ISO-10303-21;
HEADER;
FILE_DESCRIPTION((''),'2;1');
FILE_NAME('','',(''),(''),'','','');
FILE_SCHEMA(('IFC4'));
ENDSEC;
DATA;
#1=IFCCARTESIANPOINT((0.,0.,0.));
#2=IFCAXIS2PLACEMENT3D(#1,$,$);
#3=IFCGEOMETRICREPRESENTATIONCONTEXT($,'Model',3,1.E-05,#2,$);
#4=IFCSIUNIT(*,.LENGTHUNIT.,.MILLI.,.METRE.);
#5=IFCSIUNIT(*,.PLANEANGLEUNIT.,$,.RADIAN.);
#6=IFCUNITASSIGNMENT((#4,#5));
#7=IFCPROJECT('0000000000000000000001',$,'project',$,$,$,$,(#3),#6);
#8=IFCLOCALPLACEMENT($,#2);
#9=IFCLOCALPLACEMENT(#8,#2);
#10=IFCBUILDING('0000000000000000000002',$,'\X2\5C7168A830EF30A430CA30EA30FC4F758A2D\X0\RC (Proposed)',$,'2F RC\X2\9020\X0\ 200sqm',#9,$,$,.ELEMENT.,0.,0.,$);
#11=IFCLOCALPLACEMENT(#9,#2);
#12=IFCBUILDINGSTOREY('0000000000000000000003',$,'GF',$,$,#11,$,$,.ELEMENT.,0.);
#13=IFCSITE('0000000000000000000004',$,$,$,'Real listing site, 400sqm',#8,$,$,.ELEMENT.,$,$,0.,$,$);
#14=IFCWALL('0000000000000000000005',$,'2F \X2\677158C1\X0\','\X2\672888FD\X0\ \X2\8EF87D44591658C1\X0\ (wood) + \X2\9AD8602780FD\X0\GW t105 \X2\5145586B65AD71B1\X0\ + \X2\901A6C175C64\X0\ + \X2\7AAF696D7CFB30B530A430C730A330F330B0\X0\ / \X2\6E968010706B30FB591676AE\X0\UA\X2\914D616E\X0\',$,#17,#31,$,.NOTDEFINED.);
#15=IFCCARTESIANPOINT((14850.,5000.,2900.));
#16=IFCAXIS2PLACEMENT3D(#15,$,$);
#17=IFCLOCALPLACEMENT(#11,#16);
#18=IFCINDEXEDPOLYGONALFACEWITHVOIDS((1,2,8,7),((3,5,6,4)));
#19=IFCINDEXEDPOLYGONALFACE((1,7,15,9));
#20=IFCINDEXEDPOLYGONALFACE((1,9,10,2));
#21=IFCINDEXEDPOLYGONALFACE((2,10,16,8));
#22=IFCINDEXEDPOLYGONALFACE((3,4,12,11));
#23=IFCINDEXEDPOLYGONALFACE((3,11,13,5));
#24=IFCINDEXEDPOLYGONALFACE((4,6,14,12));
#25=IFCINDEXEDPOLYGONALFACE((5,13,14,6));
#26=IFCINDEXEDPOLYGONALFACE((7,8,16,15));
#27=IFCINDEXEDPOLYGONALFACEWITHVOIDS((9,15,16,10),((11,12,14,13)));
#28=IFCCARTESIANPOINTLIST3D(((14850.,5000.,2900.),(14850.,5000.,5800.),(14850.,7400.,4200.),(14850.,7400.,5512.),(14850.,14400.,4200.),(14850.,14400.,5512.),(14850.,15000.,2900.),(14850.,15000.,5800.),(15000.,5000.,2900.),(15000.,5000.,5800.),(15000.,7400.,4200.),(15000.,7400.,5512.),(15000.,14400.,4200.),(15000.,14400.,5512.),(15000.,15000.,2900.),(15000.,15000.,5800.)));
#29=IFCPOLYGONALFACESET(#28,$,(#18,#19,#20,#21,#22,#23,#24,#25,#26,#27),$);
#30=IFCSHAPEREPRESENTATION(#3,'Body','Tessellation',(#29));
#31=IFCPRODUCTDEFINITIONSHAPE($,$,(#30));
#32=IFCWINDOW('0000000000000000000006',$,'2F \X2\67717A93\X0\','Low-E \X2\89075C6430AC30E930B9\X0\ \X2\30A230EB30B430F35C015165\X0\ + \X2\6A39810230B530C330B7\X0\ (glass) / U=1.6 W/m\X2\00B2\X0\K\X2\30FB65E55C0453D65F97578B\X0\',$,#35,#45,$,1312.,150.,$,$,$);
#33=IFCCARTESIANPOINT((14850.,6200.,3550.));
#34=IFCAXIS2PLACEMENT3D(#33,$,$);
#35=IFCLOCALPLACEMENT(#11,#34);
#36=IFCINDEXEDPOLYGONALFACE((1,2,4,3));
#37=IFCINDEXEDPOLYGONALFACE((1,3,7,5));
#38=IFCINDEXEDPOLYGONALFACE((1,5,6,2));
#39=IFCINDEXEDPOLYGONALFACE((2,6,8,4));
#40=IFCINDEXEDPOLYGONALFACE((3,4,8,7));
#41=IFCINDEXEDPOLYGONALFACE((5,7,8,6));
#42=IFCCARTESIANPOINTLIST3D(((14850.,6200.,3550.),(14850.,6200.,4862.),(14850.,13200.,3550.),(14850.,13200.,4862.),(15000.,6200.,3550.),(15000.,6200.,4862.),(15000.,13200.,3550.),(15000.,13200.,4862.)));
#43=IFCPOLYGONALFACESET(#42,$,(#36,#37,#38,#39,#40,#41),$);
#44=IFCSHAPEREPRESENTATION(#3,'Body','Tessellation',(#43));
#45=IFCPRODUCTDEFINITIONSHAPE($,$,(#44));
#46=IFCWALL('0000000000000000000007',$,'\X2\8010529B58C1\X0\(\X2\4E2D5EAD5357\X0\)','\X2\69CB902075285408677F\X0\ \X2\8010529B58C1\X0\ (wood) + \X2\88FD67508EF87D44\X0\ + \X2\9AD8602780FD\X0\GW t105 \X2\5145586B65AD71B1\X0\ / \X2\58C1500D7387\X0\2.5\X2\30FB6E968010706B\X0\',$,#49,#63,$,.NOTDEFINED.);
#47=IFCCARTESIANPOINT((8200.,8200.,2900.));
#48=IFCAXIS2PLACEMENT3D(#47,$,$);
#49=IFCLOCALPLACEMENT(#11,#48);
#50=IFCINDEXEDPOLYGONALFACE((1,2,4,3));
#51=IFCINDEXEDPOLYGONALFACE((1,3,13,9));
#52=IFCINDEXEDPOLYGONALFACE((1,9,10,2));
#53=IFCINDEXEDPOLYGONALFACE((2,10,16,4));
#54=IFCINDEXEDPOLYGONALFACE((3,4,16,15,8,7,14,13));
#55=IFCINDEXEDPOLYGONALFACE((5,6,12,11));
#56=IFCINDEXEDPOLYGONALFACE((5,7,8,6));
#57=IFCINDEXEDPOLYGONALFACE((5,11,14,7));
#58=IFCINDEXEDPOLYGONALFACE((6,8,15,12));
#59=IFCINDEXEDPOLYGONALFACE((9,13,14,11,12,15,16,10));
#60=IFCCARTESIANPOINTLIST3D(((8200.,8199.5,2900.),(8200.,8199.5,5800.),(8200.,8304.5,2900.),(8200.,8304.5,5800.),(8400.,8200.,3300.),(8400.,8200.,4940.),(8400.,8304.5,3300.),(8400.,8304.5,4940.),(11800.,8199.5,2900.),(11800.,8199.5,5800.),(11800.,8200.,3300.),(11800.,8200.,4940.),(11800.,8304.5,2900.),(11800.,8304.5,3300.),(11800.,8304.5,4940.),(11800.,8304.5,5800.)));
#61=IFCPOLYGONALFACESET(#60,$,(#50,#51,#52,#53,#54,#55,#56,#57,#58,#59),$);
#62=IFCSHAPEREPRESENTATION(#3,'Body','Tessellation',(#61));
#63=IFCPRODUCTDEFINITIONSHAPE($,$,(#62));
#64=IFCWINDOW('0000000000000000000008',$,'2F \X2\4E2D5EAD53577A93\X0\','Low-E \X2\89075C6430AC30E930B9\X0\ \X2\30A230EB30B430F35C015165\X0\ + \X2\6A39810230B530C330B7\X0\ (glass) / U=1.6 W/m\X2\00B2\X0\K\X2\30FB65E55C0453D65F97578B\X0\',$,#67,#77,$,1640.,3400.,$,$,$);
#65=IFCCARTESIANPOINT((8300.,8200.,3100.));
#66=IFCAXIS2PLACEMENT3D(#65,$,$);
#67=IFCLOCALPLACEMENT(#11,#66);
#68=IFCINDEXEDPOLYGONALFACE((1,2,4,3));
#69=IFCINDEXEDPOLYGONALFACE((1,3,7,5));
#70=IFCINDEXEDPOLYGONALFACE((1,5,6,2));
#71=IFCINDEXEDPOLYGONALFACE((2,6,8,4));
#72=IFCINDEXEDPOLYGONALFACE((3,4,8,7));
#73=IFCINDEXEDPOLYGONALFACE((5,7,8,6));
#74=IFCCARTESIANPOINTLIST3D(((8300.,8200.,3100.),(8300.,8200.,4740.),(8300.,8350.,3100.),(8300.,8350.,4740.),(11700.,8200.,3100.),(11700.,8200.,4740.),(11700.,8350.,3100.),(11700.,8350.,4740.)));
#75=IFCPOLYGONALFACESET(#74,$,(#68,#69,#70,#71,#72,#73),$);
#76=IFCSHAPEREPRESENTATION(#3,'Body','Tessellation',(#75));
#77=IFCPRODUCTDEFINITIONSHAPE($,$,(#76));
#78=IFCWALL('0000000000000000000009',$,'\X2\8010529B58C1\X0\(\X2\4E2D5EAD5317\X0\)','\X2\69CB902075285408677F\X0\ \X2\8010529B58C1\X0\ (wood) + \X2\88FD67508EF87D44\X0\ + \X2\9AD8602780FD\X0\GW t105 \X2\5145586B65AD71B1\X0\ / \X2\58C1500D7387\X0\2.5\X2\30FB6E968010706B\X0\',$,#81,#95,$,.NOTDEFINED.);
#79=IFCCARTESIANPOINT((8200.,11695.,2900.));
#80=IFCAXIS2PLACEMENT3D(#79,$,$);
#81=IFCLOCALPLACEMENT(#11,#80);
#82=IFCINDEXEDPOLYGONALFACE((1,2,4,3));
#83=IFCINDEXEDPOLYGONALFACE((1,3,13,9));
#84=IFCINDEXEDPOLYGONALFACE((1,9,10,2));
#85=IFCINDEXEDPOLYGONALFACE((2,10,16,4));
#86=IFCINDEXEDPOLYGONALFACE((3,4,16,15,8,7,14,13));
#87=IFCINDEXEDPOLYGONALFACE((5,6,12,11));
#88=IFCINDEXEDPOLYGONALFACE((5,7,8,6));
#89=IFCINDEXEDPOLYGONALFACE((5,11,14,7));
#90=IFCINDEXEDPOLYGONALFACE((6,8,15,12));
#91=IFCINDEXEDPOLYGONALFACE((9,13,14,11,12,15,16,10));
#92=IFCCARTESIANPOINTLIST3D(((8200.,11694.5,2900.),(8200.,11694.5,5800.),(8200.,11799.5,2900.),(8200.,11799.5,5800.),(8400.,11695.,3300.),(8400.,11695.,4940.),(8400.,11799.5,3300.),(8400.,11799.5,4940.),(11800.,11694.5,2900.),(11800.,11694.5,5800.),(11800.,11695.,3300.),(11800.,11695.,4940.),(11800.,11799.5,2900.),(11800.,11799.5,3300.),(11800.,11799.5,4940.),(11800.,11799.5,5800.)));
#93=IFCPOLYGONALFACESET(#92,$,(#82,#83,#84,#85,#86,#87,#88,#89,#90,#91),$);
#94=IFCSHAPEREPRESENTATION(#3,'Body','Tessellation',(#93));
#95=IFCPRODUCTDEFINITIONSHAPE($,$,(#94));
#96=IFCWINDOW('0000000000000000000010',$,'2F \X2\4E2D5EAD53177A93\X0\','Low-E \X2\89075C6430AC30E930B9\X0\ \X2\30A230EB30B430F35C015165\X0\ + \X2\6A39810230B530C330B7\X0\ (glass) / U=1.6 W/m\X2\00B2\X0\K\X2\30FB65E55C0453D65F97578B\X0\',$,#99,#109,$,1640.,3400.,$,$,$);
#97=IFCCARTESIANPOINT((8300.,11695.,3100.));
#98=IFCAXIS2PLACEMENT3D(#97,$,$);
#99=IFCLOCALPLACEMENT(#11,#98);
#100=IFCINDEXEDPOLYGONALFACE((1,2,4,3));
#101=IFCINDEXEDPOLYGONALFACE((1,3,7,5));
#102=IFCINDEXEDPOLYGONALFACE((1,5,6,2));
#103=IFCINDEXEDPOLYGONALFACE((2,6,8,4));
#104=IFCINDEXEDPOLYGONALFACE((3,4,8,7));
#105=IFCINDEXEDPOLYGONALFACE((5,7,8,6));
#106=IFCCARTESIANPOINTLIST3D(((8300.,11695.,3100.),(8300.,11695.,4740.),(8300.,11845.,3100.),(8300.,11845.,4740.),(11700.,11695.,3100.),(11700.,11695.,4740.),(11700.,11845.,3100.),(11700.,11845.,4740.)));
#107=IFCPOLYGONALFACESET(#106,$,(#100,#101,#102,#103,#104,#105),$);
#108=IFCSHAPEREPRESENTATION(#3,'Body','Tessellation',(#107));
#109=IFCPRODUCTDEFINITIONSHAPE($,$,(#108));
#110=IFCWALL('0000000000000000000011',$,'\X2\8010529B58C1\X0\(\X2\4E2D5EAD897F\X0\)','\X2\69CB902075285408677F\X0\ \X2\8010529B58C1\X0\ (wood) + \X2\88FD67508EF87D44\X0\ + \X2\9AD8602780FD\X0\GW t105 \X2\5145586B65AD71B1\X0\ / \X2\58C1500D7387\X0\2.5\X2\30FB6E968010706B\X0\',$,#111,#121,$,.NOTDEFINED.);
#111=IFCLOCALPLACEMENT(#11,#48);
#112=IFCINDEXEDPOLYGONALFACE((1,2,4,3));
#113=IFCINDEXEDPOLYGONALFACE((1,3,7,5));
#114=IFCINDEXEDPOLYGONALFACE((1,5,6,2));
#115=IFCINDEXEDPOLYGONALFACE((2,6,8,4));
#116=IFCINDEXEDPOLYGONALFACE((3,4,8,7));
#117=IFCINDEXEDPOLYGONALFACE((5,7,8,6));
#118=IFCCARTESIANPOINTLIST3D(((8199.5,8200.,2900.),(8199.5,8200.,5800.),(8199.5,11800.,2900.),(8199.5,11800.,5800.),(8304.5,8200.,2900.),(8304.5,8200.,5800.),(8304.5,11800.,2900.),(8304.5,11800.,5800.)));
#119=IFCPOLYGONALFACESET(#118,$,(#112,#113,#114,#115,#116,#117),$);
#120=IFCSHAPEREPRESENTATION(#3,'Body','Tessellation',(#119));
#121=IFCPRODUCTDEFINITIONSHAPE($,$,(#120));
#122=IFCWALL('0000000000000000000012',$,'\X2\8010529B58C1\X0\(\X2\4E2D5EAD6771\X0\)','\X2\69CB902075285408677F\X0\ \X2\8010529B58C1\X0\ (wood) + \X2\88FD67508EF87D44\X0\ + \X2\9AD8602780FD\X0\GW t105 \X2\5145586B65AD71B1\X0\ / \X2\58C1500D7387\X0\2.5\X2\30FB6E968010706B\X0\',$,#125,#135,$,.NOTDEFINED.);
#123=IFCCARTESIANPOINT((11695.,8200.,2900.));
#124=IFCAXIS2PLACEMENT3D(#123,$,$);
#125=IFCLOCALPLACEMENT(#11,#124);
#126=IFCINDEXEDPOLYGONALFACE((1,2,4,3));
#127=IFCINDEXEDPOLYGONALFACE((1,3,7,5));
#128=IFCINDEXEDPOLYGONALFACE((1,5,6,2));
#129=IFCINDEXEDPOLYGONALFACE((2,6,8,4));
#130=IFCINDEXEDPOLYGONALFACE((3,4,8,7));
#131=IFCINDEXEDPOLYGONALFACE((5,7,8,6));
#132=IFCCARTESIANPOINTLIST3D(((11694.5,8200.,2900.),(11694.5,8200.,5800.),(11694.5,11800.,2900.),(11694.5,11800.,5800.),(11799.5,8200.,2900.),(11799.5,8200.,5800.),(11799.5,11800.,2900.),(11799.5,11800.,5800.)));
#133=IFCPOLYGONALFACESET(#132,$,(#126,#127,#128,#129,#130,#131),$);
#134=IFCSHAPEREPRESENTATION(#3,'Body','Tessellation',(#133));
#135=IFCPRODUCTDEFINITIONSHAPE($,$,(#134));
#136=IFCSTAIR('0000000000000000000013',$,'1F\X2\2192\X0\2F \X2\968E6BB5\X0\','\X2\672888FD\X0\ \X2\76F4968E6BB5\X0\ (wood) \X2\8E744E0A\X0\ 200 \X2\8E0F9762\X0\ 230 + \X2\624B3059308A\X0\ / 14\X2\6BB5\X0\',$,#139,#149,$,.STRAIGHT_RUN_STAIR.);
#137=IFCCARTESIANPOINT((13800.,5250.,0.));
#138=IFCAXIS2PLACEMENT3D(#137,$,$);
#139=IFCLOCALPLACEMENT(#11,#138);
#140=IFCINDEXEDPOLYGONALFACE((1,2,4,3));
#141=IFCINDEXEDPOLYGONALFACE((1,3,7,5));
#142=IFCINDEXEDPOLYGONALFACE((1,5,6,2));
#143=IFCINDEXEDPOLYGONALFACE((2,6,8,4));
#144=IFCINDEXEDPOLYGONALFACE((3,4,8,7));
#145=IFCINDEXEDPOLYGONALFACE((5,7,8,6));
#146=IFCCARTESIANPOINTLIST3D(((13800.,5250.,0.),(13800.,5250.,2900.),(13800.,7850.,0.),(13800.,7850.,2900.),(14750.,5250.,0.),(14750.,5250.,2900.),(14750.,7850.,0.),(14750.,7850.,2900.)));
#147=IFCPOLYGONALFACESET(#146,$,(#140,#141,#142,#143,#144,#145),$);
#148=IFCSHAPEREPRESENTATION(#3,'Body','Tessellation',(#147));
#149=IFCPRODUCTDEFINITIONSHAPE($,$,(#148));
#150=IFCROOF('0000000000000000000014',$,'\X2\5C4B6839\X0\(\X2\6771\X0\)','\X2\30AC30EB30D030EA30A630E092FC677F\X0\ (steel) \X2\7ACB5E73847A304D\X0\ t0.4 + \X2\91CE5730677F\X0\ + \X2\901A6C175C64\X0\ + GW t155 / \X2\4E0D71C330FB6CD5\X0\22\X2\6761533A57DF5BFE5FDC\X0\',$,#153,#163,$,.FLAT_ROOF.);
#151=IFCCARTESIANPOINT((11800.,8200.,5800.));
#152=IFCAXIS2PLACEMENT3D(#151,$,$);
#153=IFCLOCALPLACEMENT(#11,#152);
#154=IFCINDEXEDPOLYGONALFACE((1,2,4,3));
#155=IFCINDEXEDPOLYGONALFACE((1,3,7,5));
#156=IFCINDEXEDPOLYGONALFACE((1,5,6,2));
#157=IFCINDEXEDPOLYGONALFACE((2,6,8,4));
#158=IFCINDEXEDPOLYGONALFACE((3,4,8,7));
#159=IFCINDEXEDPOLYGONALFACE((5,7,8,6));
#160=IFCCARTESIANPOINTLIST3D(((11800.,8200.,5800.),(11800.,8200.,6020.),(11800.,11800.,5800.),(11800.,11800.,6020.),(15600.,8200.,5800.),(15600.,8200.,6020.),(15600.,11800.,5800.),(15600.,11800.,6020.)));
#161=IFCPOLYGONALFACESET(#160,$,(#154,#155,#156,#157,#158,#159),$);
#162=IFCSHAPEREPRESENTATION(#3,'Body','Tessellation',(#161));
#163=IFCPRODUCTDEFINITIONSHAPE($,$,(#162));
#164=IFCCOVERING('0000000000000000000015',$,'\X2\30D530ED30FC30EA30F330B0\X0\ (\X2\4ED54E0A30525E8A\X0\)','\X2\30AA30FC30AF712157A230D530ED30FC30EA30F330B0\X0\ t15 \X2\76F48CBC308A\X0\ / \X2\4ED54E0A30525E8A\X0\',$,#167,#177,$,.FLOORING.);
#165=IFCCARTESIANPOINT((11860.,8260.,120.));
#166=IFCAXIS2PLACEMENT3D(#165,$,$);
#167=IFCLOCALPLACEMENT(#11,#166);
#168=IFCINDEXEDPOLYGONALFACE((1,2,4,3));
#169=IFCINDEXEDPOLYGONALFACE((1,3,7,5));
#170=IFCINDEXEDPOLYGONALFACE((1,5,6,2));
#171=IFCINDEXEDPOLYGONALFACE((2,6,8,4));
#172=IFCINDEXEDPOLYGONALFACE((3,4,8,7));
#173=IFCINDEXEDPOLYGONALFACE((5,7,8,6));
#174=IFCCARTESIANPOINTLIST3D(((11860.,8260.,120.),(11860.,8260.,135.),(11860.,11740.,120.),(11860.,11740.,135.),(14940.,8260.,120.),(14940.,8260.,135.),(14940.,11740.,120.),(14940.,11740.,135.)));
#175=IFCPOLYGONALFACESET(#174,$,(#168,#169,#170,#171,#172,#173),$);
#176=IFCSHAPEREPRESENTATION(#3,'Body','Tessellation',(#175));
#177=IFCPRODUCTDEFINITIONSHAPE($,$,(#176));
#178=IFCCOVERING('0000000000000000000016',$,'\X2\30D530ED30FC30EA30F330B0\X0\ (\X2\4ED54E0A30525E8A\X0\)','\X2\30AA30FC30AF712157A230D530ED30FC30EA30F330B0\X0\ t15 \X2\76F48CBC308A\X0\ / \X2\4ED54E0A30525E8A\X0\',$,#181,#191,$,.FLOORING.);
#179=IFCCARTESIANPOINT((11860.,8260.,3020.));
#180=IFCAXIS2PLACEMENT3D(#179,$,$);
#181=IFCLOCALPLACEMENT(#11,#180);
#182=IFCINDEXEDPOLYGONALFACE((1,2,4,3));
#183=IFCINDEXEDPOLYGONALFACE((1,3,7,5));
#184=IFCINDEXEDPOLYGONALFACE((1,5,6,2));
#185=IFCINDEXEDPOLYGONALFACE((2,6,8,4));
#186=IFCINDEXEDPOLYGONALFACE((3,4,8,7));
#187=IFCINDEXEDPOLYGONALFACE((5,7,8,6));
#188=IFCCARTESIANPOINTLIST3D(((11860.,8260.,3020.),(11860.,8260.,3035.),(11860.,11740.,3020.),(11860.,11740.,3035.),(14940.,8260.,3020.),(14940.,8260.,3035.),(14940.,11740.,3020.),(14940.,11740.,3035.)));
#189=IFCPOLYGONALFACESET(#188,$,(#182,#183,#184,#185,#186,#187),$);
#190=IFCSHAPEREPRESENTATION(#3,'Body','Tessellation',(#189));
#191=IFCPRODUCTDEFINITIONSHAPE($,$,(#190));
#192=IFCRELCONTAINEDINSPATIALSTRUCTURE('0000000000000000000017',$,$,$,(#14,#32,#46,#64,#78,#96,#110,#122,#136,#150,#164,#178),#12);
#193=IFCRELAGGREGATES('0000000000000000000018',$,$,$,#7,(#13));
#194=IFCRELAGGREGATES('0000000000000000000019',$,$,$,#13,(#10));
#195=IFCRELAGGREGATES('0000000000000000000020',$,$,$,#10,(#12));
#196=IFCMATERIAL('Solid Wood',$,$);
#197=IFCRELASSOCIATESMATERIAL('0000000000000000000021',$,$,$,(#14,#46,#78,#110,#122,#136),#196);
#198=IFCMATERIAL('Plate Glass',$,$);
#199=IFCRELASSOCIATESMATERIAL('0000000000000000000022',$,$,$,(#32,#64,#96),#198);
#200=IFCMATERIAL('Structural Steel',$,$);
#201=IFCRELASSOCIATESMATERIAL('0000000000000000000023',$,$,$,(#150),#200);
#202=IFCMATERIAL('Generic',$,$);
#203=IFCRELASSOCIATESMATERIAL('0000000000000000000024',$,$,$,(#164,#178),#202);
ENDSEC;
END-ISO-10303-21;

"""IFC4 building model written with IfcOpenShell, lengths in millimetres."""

from ifc_helpers import new_model, si_unit, frame, frame_2d, origin, place, context, project, spatial, rectangle, extrude, material, element, fill, save


model = new_model("IFC4")

# Units and contexts
model_context = context("Model", 3, precision=1e-05, world=origin())
ifc_project = project(units=[si_unit("LENGTHUNIT", "METRE", prefix="MILLI"), si_unit("PLANEANGLEUNIT", "RADIAN")], contexts=[model_context])

# Site, building, storey
site_placement = place(None, origin())
site = spatial("IfcSite", under=ifc_project, at=site_placement, ObjectType="Real listing site, 400sqm", CompositionType="ELEMENT", RefElevation=0.0)
building_placement = place(site_placement, origin())
building = spatial("IfcBuilding", under=site, at=building_placement, Name="山梨ワイナリー併設RC (Proposed)", ObjectType="2F RC造 200sqm", CompositionType="ELEMENT", ElevationOfRefHeight=0.0, ElevationOfTerrain=0.0)
storey_placement = place(building_placement, origin())
storey = spatial("IfcBuildingStorey", under=building, at=storey_placement, Name="GF", CompositionType="ELEMENT", Elevation=0.0)

# Shared definitions
ifc_material_1 = material(Name="Solid Wood")

# Shared definitions
ifc_material_2 = material(Name="Plate Glass")

# Walls, openings, windows
wall_1_placement = place(storey_placement, frame((14850.0, 5000.0, 2900.0)))
wall_1 = element("IfcWall", 1, at=wall_1_placement, inside=storey, material=ifc_material_1, Name="2F 東壁", Description="木製 軸組外壁 (wood) + 高性能GW t105 充填断熱 + 通気層 + 窯業系サイディング / 準耐火・外皮UA配慮", PredefinedType="NOTDEFINED", context=model_context, shape_type="SweptSolid", body=[
    extrude(rectangle(XDim=150.0, YDim=10000.0, at=frame_2d((75.0, 5000.0))), frame((14850.0, 5000.0, 2900.0)), (0.0, 0.0, 1.0), 2900.0),
])
opening_1_placement = place(storey_placement, frame((14850.0, 6200.0, 3550.0)))
opening_1 = element("IfcOpeningElement", 2, at=opening_1_placement, cuts=wall_1, PredefinedType="NOTDEFINED", context=model_context, shape_type="SweptSolid", body=[
    extrude(rectangle(XDim=150.0, YDim=7000.0, at=frame_2d((75.0, 3500.0))), frame((14850.0, 6200.0, 3550.0)), (0.0, 0.0, 1.0), 1312.0),
])
window_1_placement = place(storey_placement, frame((14850.0, 6200.0, 3550.0)))
window_1 = element("IfcWindow", 3, at=window_1_placement, inside=storey, material=ifc_material_2, Name="2F 東窓", Description="Low-E 複層ガラス アルゴン封入 + 樹脂サッシ (glass) / U=1.6 W/m²K・日射取得型", OverallHeight=1312.0, OverallWidth=150.0, context=model_context, shape_type="SweptSolid", body=[
    extrude(rectangle(XDim=150.0, YDim=7000.0, at=frame_2d((75.0, 3500.0))), frame((14850.0, 6200.0, 3550.0)), (0.0, 0.0, 1.0), 1312.0),
])
fill(opening_1, window_1)
wall_2_placement = place(storey_placement, frame((8200.0, 8200.0, 2900.0)))
wall_2 = element("IfcWall", 4, at=wall_2_placement, inside=storey, material=ifc_material_1, Name="耐力壁(中庭南)", Description="構造用合板 耐力壁 (wood) + 製材軸組 + 高性能GW t105 充填断熱 / 壁倍率2.5・準耐火", PredefinedType="NOTDEFINED", context=model_context, shape_type="SweptSolid", body=[
    extrude(rectangle(XDim=3600.0, YDim=105.0, at=frame_2d((1800.0, 52.0))), frame((8200.0, 8200.0, 2900.0)), (0.0, 0.0, 1.0), 2900.0),
])
opening_2_placement = place(storey_placement, frame((8300.0, 8200.0, 3100.0)))
opening_2 = element("IfcOpeningElement", 5, at=opening_2_placement, cuts=wall_2, PredefinedType="NOTDEFINED", context=model_context, shape_type="SweptSolid", body=[
    extrude(rectangle(XDim=3400.0, YDim=150.0, at=frame_2d((1700.0, 75.0))), frame((8300.0, 8200.0, 3100.0)), (0.0, 0.0, 1.0), 1640.0),
])
window_2_placement = place(storey_placement, frame((8300.0, 8200.0, 3100.0)))
window_2 = element("IfcWindow", 6, at=window_2_placement, inside=storey, material=ifc_material_2, Name="2F 中庭南窓", Description="Low-E 複層ガラス アルゴン封入 + 樹脂サッシ (glass) / U=1.6 W/m²K・日射取得型", OverallHeight=1640.0, OverallWidth=3400.0, context=model_context, shape_type="SweptSolid", body=[
    extrude(rectangle(XDim=3400.0, YDim=150.0, at=frame_2d((1700.0, 75.0))), frame((8300.0, 8200.0, 3100.0)), (0.0, 0.0, 1.0), 1640.0),
])
fill(opening_2, window_2)
wall_3_placement = place(storey_placement, frame((8200.0, 11695.0, 2900.0)))
wall_3 = element("IfcWall", 7, at=wall_3_placement, inside=storey, material=ifc_material_1, Name="耐力壁(中庭北)", Description="構造用合板 耐力壁 (wood) + 製材軸組 + 高性能GW t105 充填断熱 / 壁倍率2.5・準耐火", PredefinedType="NOTDEFINED", context=model_context, shape_type="SweptSolid", body=[
    extrude(rectangle(XDim=3600.0, YDim=105.0, at=frame_2d((1800.0, 52.0))), frame((8200.0, 11695.0, 2900.0)), (0.0, 0.0, 1.0), 2900.0),
])
opening_3_placement = place(storey_placement, frame((8300.0, 11695.0, 3100.0)))
opening_3 = element("IfcOpeningElement", 8, at=opening_3_placement, cuts=wall_3, PredefinedType="NOTDEFINED", context=model_context, shape_type="SweptSolid", body=[
    extrude(rectangle(XDim=3400.0, YDim=150.0, at=frame_2d((1700.0, 75.0))), frame((8300.0, 11695.0, 3100.0)), (0.0, 0.0, 1.0), 1640.0),
])
window_3_placement = place(storey_placement, frame((8300.0, 11695.0, 3100.0)))
window_3 = element("IfcWindow", 9, at=window_3_placement, inside=storey, material=ifc_material_2, Name="2F 中庭北窓", Description="Low-E 複層ガラス アルゴン封入 + 樹脂サッシ (glass) / U=1.6 W/m²K・日射取得型", OverallHeight=1640.0, OverallWidth=3400.0, context=model_context, shape_type="SweptSolid", body=[
    extrude(rectangle(XDim=3400.0, YDim=150.0, at=frame_2d((1700.0, 75.0))), frame((8300.0, 11695.0, 3100.0)), (0.0, 0.0, 1.0), 1640.0),
])
fill(opening_3, window_3)

# Walls
wall_4_placement = place(storey_placement, frame((8200.0, 8200.0, 2900.0)))
element("IfcWall", 10, at=wall_4_placement, inside=storey, material=ifc_material_1, Name="耐力壁(中庭西)", Description="構造用合板 耐力壁 (wood) + 製材軸組 + 高性能GW t105 充填断熱 / 壁倍率2.5・準耐火", PredefinedType="NOTDEFINED", context=model_context, shape_type="SweptSolid", body=[
    extrude(rectangle(XDim=105.0, YDim=3600.0, at=frame_2d((52.0, 1800.0))), frame((8200.0, 8200.0, 2900.0)), (0.0, 0.0, 1.0), 2900.0),
])
wall_5_placement = place(storey_placement, frame((11695.0, 8200.0, 2900.0)))
element("IfcWall", 11, at=wall_5_placement, inside=storey, material=ifc_material_1, Name="耐力壁(中庭東)", Description="構造用合板 耐力壁 (wood) + 製材軸組 + 高性能GW t105 充填断熱 / 壁倍率2.5・準耐火", PredefinedType="NOTDEFINED", context=model_context, shape_type="SweptSolid", body=[
    extrude(rectangle(XDim=105.0, YDim=3600.0, at=frame_2d((52.0, 1800.0))), frame((11695.0, 8200.0, 2900.0)), (0.0, 0.0, 1.0), 2900.0),
])

# Stair
stair_placement = place(storey_placement, frame((13800.0, 5250.0, 0.0)))
element("IfcStair", 12, at=stair_placement, inside=storey, material=ifc_material_1, Name="1F→2F 階段", Description="木製 直階段 (wood) 蹴上 200 踏面 230 + 手すり / 14段", PredefinedType="STRAIGHT_RUN_STAIR", context=model_context, shape_type="SweptSolid", body=[
    extrude(rectangle(XDim=950.0, YDim=2600.0, at=frame_2d((475.0, 1300.0))), frame((13800.0, 5250.0, 0.0)), (0.0, 0.0, 1.0), 2900.0),
])

# Roof
ifc_material_3 = material(Name="Structural Steel")
for number, where, name in (
    (13, (11800.0, 8200.0, 5800.0), "屋根(東)"),
):
    element("IfcRoof", number, at=place(storey_placement, frame(where)), inside=storey, material=ifc_material_3, Name=name, Description="ガルバリウム鋼板 (steel) 立平葺き t0.4 + 野地板 + 通気層 + GW t155 / 不燃・法22条区域対応", PredefinedType="FLAT_ROOF", context=model_context, shape_type="SweptSolid", body=[
        extrude(rectangle(XDim=3800.0, YDim=3600.0, at=frame_2d((1900.0, 1800.0))), frame((11800.0, 8200.0, 5800.0)), (0.0, 0.0, 1.0), 220.0),
    ])

# Coverings
ifc_material_4 = material(Name="Generic")
covering_1_placement = place(storey_placement, frame((11860.0, 8260.0, 120.0)))
element("IfcCovering", 14, at=covering_1_placement, inside=storey, material=ifc_material_4, Name="フローリング (仕上げ床)", Description="オーク無垢フローリング t15 直貼り / 仕上げ床", PredefinedType="FLOORING", context=model_context, shape_type="SweptSolid", body=[
    extrude(rectangle(XDim=3080.0, YDim=3480.0, at=frame_2d((1540.0, 1740.0))), frame((11860.0, 8260.0, 120.0)), (0.0, 0.0, 1.0), 15.0),
])
covering_2_placement = place(storey_placement, frame((11860.0, 8260.0, 3020.0)))
element("IfcCovering", 15, at=covering_2_placement, inside=storey, material=ifc_material_4, Name="フローリング (仕上げ床)", Description="オーク無垢フローリング t15 直貼り / 仕上げ床", PredefinedType="FLOORING", context=model_context, shape_type="SweptSolid", body=[
    extrude(rectangle(XDim=3080.0, YDim=3480.0, at=frame_2d((1540.0, 1740.0))), frame((11860.0, 8260.0, 3020.0)), (0.0, 0.0, 1.0), 15.0),
])

save(model, "model.ifc")
